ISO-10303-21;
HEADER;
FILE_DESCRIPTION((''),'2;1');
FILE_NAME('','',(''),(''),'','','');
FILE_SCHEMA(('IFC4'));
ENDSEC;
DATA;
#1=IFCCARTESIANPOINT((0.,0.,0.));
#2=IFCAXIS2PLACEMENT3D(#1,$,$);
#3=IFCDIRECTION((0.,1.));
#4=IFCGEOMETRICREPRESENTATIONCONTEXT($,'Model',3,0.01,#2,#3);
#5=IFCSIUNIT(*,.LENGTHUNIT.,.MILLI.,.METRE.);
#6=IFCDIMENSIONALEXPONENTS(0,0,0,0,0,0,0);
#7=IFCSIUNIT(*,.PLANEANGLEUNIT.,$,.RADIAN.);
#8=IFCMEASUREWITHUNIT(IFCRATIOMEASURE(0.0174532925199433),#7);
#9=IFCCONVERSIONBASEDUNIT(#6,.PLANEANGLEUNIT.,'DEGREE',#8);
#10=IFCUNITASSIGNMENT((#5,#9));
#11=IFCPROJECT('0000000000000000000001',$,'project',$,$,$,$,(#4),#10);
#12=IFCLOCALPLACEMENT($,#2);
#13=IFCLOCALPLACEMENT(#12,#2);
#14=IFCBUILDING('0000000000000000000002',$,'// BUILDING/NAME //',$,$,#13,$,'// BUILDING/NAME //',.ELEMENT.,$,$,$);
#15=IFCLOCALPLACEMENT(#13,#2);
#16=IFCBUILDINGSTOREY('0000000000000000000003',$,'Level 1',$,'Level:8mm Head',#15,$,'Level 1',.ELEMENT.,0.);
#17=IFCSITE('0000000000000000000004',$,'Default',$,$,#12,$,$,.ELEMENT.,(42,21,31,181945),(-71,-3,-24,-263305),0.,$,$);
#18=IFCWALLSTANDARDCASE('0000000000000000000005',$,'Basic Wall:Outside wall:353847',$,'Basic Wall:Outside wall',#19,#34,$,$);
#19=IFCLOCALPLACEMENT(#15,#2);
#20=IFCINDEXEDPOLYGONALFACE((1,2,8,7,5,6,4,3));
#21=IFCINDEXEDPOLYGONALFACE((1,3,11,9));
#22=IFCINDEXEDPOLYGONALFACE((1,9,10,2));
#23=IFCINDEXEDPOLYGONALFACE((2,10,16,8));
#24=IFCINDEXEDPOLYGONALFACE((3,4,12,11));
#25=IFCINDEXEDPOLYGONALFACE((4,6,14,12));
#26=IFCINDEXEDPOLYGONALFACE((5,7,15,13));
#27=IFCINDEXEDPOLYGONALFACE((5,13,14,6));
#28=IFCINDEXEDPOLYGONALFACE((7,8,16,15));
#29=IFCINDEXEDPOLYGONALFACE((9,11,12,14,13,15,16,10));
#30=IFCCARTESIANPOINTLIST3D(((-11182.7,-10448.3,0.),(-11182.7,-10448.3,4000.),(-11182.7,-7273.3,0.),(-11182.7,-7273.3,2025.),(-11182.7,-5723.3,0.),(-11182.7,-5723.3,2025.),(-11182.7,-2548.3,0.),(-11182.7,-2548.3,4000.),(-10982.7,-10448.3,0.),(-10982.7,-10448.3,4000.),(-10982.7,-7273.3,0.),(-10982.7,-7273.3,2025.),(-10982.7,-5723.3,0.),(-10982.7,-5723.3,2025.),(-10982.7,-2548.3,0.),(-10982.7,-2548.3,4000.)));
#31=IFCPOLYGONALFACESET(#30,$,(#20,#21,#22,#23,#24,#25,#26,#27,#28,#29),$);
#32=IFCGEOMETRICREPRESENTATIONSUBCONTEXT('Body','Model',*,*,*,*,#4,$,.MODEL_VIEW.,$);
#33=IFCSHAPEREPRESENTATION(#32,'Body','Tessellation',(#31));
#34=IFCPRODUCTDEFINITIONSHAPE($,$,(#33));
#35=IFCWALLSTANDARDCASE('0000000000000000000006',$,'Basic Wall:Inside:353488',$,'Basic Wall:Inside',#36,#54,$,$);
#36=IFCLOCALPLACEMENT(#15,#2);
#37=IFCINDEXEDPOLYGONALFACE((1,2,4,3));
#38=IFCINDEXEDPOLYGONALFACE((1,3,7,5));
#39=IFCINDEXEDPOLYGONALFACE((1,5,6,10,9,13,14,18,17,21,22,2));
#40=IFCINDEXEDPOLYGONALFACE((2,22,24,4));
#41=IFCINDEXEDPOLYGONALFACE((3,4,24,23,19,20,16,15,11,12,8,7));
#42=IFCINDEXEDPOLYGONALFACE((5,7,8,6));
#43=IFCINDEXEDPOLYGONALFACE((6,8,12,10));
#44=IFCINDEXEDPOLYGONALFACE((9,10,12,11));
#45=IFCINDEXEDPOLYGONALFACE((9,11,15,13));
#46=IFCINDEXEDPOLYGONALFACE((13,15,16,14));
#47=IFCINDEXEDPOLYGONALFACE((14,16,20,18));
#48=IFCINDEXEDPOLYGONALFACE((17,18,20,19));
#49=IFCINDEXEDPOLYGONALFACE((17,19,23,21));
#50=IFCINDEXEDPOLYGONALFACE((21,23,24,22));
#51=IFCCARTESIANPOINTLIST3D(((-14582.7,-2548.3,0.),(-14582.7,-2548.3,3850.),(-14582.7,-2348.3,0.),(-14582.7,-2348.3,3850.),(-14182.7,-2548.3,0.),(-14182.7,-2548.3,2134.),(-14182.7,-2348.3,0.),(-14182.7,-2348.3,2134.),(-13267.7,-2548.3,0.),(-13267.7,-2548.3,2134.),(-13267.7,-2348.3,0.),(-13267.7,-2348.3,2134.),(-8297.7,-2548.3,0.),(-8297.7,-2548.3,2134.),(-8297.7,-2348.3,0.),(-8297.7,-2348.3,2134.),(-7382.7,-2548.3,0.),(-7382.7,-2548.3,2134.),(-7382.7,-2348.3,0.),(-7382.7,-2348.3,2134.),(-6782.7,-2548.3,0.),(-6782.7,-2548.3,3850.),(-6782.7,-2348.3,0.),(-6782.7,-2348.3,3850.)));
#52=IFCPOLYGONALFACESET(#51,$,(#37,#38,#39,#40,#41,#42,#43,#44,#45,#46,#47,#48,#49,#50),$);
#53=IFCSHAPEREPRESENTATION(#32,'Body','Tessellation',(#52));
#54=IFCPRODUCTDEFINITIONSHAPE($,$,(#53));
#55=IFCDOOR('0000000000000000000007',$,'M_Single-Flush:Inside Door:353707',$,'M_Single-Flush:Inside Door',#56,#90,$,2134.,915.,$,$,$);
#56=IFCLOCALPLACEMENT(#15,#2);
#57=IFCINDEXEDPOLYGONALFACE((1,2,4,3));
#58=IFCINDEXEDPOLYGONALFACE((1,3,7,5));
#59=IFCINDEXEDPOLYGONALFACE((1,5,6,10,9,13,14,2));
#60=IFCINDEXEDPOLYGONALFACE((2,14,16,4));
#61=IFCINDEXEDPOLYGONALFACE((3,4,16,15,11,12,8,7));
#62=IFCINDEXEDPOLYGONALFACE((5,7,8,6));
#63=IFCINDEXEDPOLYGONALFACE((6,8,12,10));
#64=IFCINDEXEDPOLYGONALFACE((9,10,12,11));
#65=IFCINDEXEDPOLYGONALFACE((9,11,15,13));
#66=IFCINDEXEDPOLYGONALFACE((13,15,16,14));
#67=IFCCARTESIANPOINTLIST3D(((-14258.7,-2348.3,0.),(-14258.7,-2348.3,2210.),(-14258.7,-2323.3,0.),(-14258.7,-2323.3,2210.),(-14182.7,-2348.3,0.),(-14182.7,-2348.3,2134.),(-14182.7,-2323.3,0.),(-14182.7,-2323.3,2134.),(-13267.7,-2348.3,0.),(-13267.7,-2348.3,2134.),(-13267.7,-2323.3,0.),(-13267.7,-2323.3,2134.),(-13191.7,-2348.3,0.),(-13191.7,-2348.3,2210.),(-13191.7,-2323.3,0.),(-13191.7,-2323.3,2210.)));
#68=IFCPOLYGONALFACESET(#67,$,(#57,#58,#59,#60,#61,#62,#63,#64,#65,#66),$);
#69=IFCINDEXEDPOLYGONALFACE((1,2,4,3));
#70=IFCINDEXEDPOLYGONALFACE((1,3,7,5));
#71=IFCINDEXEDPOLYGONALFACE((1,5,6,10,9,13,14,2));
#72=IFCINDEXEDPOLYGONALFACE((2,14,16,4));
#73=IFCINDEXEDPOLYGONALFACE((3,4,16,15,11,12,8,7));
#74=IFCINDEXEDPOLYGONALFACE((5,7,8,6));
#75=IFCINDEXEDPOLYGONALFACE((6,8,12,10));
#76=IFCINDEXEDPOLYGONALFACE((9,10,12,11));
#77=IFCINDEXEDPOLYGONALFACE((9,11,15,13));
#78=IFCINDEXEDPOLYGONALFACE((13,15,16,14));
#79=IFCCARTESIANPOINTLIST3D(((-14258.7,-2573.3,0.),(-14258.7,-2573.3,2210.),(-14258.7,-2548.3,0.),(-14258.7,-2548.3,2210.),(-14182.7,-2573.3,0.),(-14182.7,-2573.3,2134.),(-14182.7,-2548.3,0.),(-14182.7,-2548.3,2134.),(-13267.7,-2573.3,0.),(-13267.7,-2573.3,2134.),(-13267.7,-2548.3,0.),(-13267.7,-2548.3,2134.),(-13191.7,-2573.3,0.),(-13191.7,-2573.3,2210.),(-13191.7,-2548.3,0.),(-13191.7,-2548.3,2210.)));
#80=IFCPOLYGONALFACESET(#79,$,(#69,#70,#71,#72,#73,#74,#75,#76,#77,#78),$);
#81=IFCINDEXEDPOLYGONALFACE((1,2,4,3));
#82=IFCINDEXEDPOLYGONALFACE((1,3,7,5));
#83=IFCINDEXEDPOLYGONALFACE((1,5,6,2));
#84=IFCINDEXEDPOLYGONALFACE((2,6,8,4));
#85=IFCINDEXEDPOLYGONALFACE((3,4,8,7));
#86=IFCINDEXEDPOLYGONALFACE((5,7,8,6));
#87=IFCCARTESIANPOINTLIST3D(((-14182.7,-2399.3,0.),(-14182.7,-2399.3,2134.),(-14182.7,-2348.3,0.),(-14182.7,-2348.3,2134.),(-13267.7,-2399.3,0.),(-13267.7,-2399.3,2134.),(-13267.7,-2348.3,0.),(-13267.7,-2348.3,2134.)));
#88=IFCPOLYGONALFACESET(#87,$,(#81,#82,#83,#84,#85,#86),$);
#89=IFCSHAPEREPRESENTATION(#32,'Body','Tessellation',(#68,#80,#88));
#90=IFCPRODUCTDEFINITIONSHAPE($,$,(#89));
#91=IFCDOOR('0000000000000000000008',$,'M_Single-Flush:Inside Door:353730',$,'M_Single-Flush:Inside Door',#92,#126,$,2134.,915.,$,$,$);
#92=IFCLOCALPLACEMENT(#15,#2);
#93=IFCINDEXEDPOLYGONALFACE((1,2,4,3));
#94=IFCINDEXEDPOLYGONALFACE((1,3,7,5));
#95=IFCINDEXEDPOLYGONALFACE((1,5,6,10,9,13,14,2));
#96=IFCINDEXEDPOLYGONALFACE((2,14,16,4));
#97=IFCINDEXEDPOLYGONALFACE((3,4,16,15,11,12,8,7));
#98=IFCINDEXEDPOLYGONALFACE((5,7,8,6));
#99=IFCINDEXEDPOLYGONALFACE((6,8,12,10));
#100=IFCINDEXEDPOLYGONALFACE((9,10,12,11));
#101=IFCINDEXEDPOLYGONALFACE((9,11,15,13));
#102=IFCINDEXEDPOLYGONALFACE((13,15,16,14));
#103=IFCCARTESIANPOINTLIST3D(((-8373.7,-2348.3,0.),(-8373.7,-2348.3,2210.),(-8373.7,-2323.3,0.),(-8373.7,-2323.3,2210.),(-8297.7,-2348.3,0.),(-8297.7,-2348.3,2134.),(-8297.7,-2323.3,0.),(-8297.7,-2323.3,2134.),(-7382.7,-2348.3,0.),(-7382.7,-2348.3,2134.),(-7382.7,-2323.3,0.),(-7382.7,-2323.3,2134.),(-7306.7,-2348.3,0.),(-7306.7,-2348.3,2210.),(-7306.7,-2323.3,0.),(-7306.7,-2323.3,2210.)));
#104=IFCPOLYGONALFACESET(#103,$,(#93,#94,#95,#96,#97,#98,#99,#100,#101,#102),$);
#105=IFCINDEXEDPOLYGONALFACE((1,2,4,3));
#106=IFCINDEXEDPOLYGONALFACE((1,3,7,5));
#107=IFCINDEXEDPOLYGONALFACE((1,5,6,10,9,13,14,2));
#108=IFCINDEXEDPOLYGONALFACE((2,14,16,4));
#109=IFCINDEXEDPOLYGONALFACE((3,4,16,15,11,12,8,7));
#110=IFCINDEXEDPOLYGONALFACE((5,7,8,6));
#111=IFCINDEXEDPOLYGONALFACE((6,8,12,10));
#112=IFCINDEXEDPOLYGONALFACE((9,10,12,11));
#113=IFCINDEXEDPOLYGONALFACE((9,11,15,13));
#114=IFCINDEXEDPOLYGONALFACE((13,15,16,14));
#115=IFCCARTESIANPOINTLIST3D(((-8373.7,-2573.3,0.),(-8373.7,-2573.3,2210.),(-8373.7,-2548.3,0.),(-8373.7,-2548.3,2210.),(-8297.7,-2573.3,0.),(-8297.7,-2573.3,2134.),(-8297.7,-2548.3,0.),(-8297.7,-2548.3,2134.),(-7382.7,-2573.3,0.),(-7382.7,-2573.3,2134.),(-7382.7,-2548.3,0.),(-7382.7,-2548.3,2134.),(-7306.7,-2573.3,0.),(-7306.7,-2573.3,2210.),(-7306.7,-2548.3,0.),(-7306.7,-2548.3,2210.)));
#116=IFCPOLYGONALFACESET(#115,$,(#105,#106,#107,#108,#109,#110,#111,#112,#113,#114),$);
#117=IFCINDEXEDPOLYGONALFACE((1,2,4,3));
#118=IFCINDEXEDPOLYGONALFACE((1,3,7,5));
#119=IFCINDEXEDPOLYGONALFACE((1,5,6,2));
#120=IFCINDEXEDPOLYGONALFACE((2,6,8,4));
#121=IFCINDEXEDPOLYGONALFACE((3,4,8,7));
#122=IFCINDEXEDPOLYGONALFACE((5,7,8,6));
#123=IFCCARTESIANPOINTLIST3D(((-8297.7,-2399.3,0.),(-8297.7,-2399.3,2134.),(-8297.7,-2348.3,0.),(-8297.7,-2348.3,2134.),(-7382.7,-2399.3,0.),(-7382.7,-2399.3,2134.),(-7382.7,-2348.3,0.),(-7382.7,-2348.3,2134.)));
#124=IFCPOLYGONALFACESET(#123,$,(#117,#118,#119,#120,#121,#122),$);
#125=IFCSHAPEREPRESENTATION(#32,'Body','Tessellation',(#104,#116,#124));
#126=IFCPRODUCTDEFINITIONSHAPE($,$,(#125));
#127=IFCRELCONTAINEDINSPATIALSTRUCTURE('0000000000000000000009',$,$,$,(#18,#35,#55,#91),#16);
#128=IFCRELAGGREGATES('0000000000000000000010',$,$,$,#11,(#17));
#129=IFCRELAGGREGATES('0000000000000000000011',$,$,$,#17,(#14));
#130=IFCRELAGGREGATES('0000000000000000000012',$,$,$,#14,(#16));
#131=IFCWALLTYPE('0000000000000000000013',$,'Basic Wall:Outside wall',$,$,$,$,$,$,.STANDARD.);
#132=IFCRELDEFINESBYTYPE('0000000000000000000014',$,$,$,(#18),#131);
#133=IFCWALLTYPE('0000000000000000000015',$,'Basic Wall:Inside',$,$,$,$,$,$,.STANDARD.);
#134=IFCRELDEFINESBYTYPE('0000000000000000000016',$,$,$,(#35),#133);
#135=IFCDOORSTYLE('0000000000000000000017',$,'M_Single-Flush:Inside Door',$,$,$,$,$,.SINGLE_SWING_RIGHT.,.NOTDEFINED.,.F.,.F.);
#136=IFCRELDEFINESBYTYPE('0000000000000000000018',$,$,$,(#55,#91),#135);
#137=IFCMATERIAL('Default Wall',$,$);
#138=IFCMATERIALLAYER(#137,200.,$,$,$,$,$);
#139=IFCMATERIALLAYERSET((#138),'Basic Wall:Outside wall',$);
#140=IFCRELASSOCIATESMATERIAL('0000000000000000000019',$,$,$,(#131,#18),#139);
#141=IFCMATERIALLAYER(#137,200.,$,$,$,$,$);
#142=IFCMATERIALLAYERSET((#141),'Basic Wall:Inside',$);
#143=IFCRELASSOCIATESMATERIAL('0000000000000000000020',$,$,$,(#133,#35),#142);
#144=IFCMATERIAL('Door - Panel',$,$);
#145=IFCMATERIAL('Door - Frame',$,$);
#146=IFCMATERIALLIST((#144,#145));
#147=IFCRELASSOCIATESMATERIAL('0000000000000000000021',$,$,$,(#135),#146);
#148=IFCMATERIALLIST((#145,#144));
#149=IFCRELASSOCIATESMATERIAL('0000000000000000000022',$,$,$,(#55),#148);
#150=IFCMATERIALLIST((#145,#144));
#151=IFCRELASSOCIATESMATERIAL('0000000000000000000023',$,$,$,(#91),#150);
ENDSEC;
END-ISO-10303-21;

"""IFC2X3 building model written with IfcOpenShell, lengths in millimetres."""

from ifc_helpers import new_model, entity, si_unit, converted_unit, direction, frame, frame_2d, origin, place, context, subcontext, project, spatial, polyline, rectangle, outline, extrude, clip, bounded_halfspace, source, transform, mapped, material, material_list, layer, layer_set, layer_usage, type_object, type_shapes, element, fill, save


model = new_model("IFC2X3")

# Units and contexts
model_context = context("Model", 3, precision=0.01, world=origin(), true_north=direction((0.0, 1.0)))
body_context = subcontext(model_context, "Body", "Model", "MODEL_VIEW")
ifc_project = project(units=[si_unit("LENGTHUNIT", "METRE", prefix="MILLI"), converted_unit("PLANEANGLEUNIT", "DEGREE", entity("IfcRatioMeasure", 0.0174532925199433), si_unit("PLANEANGLEUNIT", "RADIAN"), dimensions=[0, 0, 0, 0, 0, 0, 0])], contexts=[model_context])

# Site, building, storey
site_placement = place(None, origin())
site = spatial("IfcSite", under=ifc_project, at=site_placement, Name="Default", CompositionType="ELEMENT", RefLatitude=(42, 21, 31, 181945), RefLongitude=(-71, -3, -24, -263305), RefElevation=0.0)
building_placement = place(site_placement, origin())
building = spatial("IfcBuilding", under=site, at=building_placement, Name="// BUILDING/NAME //", LongName="// BUILDING/NAME //", CompositionType="ELEMENT")
storey_placement = place(building_placement, origin())
storey = spatial("IfcBuildingStorey", under=building, at=storey_placement, Name="Level 1", ObjectType="Level:8mm Head", LongName="Level 1", CompositionType="ELEMENT", Elevation=0.0)

# Shared definitions
ifc_material_1 = material(Name="Default Wall")
ifc_layer_1 = layer(ifc_material_1, 200.0)
ifc_layer_set_1 = layer_set([ifc_layer_1], Name="Basic Wall:Outside wall")
wall_type_1 = type_object("IfcWallType", Name="Basic Wall:Outside wall", PredefinedType="STANDARD", material=ifc_layer_set_1)
ifc_material_2 = material(Name="Door - Frame")
ifc_material_3 = material(Name="Door - Panel")

# Wall, opening
ifc_layer_usage_1 = layer_usage(ifc_layer_set_1, "AXIS2", "NEGATIVE", 100.0)
wall_1_placement = place(storey_placement, frame((-11082.7, -2548.3, 0.0), z_axis=(0.0, 0.0, 1.0), x_axis=(0.0, -1.0, 0.0)))
wall_1 = element("IfcWallStandardCase", 1, at=wall_1_placement, inside=storey, type_object=wall_type_1, material=ifc_layer_usage_1, Name="Basic Wall:Outside wall:353847", ObjectType="Basic Wall:Outside wall", context=body_context, shape_type="SweptSolid", body=[
    extrude(rectangle(XDim=7900.0, YDim=200.0, at=frame_2d((3950.0, 0.0), x_axis=(-1.0, 0.0))), origin(), (0.0, 0.0, 1.0), 4000.0),
])
opening_1_placement = place(wall_1_placement, frame((4725.0, 100.0, 0.0)))
element("IfcOpeningElement", 2, at=opening_1_placement, cuts=wall_1, ObjectType="Opening", context=body_context, shape_type="SweptSolid", body=[
    extrude(rectangle(XDim=2025.0, YDim=1550.0, at=frame_2d((1012.5, 775.0), x_axis=(1.0, 0.0))), frame((0.0, 0.0, 0.0), z_axis=(0.0, -1.0, 0.0), x_axis=(0.0, 0.0, 1.0)), (0.0, 0.0, 1.0), 200.0),
])

# Wall, openings, doors
ifc_layer_2 = layer(ifc_material_1, 200.0)
ifc_layer_set_2 = layer_set([ifc_layer_2], Name="Basic Wall:Inside")
ifc_layer_usage_2 = layer_usage(ifc_layer_set_2, "AXIS2", "NEGATIVE", 100.0)
wall_type_2 = type_object("IfcWallType", Name="Basic Wall:Inside", PredefinedType="STANDARD", material=ifc_layer_set_2)
wall_2_placement = place(storey_placement, frame((-14582.7, -2448.3, 0.0)))
wall_2 = element("IfcWallStandardCase", 3, at=wall_2_placement, inside=storey, type_object=wall_type_2, material=ifc_layer_usage_2, Name="Basic Wall:Inside:353488", ObjectType="Basic Wall:Inside", context=body_context, shape_type="Clipping", body=[
    clip(extrude(rectangle(XDim=7800.0, YDim=200.0, at=frame_2d((3900.0, 0.0), x_axis=(-1.0, 0.0))), origin(), (0.0, 0.0, 1.0), 3850.0), bounded_halfspace(frame((0.0, -100.0, 3850.0), z_axis=(0.0, 0.0, -1.0), x_axis=(1.0, 0.0, 0.0)), True, frame((0.0, -100.0, 3850.0)), polyline([(0.0, 0.0), (7800.0, 0.0), (7800.0, 200.0), (0.0, 200.0), (0.0, 0.0)]))),
])
opening_2_placement = place(wall_2_placement, frame((400.0, -100.0, 0.0)))
opening_2 = element("IfcOpeningElement", 4, at=opening_2_placement, cuts=wall_2, ObjectType="Opening", context=body_context, shape_type="SweptSolid", body=[
    extrude(rectangle(XDim=915.0, YDim=2134.0, at=frame_2d((1067.0, 457.5), x_axis=(0.0, 1.0))), frame((0.0, 0.0, 0.0), z_axis=(0.0, 1.0, 0.0), x_axis=(0.0, 0.0, 1.0)), (0.0, 0.0, 1.0), 200.0),
])
opening_3_placement = place(wall_2_placement, frame((6285.0, -100.0, 0.0)))
opening_3 = element("IfcOpeningElement", 5, at=opening_3_placement, cuts=wall_2, ObjectType="Opening", context=body_context, shape_type="SweptSolid", body=[
    extrude(rectangle(XDim=915.0, YDim=2134.0, at=frame_2d((1067.0, 457.5), x_axis=(0.0, 1.0))), frame((0.0, 0.0, 0.0), z_axis=(0.0, 1.0, 0.0), x_axis=(0.0, 0.0, 1.0)), (0.0, 0.0, 1.0), 200.0),
])
ifc_material_list_1 = material_list([ifc_material_2, ifc_material_3])
ifc_material_list_2 = material_list([ifc_material_3, ifc_material_2])
door_style_1 = type_object("IfcDoorStyle", Name="M_Single-Flush:Inside Door", ConstructionType="NOTDEFINED", OperationType="SINGLE_SWING_RIGHT", ParameterTakesPrecedence=False, Sizeable=False, material=ifc_material_list_2)
shared_shape_1 = source(origin(), body_context, "Body", "SweptSolid", [
    extrude(outline(polyline([(-533.5, -1124.0), (533.5, -1124.0), (533.5, 1086.0), (457.5, 1086.0), (457.5, -1048.0), (-457.5, -1048.0), (-457.5, 1086.0), (-533.5, 1086.0), (-533.5, -1124.0)])), frame((457.5, 200.0, 1086.0), z_axis=(0.0, 1.0, 0.0), x_axis=(1.0, 0.0, 0.0)), (0.0, 0.0, 1.0), 25.0),
    extrude(outline(polyline([(-1124.0, -533.5), (1086.0, -533.5), (1086.0, -457.5), (-1048.0, -457.5), (-1048.0, 457.5), (1086.0, 457.5), (1086.0, 533.5), (-1124.0, 533.5), (-1124.0, -533.5)])), frame((457.5, -25.0, 1086.0), z_axis=(0.0, 1.0, 0.0), x_axis=(0.0, 0.0, -1.0)), (0.0, 0.0, 1.0), 25.0),
    extrude(rectangle(XDim=51.0, YDim=915.0, at=frame_2d((0.0, 0.0), x_axis=(1.0, 0.0))), frame((457.5, 174.5, 0.0), z_axis=(0.0, 0.0, 1.0), x_axis=(0.0, 1.0, 0.0)), (0.0, 0.0, 1.0), 2134.0),
])
type_shapes(door_style_1, [shared_shape_1])
door_1_placement = place(opening_2_placement, origin())
door_1 = element("IfcDoor", 6, at=door_1_placement, inside=storey, type_object=door_style_1, material=ifc_material_list_1, Name="M_Single-Flush:Inside Door:353707", ObjectType="M_Single-Flush:Inside Door", OverallHeight=2134.0, OverallWidth=915.0, context=body_context, shape_type="MappedRepresentation", body=[
    mapped(shared_shape_1, transform((0.0, 0.0, 0.0), scale=1.0)),
])
fill(opening_2, door_1)
ifc_material_list_3 = material_list([ifc_material_2, ifc_material_3])
door_2_placement = place(opening_3_placement, origin())
door_2 = element("IfcDoor", 7, at=door_2_placement, inside=storey, type_object=door_style_1, material=ifc_material_list_3, Name="M_Single-Flush:Inside Door:353730", ObjectType="M_Single-Flush:Inside Door", OverallHeight=2134.0, OverallWidth=915.0, context=body_context, shape_type="MappedRepresentation", body=[
    mapped(shared_shape_1, transform((0.0, 0.0, 0.0), scale=1.0)),
])
fill(opening_3, door_2)

save(model, "model.ifc")
